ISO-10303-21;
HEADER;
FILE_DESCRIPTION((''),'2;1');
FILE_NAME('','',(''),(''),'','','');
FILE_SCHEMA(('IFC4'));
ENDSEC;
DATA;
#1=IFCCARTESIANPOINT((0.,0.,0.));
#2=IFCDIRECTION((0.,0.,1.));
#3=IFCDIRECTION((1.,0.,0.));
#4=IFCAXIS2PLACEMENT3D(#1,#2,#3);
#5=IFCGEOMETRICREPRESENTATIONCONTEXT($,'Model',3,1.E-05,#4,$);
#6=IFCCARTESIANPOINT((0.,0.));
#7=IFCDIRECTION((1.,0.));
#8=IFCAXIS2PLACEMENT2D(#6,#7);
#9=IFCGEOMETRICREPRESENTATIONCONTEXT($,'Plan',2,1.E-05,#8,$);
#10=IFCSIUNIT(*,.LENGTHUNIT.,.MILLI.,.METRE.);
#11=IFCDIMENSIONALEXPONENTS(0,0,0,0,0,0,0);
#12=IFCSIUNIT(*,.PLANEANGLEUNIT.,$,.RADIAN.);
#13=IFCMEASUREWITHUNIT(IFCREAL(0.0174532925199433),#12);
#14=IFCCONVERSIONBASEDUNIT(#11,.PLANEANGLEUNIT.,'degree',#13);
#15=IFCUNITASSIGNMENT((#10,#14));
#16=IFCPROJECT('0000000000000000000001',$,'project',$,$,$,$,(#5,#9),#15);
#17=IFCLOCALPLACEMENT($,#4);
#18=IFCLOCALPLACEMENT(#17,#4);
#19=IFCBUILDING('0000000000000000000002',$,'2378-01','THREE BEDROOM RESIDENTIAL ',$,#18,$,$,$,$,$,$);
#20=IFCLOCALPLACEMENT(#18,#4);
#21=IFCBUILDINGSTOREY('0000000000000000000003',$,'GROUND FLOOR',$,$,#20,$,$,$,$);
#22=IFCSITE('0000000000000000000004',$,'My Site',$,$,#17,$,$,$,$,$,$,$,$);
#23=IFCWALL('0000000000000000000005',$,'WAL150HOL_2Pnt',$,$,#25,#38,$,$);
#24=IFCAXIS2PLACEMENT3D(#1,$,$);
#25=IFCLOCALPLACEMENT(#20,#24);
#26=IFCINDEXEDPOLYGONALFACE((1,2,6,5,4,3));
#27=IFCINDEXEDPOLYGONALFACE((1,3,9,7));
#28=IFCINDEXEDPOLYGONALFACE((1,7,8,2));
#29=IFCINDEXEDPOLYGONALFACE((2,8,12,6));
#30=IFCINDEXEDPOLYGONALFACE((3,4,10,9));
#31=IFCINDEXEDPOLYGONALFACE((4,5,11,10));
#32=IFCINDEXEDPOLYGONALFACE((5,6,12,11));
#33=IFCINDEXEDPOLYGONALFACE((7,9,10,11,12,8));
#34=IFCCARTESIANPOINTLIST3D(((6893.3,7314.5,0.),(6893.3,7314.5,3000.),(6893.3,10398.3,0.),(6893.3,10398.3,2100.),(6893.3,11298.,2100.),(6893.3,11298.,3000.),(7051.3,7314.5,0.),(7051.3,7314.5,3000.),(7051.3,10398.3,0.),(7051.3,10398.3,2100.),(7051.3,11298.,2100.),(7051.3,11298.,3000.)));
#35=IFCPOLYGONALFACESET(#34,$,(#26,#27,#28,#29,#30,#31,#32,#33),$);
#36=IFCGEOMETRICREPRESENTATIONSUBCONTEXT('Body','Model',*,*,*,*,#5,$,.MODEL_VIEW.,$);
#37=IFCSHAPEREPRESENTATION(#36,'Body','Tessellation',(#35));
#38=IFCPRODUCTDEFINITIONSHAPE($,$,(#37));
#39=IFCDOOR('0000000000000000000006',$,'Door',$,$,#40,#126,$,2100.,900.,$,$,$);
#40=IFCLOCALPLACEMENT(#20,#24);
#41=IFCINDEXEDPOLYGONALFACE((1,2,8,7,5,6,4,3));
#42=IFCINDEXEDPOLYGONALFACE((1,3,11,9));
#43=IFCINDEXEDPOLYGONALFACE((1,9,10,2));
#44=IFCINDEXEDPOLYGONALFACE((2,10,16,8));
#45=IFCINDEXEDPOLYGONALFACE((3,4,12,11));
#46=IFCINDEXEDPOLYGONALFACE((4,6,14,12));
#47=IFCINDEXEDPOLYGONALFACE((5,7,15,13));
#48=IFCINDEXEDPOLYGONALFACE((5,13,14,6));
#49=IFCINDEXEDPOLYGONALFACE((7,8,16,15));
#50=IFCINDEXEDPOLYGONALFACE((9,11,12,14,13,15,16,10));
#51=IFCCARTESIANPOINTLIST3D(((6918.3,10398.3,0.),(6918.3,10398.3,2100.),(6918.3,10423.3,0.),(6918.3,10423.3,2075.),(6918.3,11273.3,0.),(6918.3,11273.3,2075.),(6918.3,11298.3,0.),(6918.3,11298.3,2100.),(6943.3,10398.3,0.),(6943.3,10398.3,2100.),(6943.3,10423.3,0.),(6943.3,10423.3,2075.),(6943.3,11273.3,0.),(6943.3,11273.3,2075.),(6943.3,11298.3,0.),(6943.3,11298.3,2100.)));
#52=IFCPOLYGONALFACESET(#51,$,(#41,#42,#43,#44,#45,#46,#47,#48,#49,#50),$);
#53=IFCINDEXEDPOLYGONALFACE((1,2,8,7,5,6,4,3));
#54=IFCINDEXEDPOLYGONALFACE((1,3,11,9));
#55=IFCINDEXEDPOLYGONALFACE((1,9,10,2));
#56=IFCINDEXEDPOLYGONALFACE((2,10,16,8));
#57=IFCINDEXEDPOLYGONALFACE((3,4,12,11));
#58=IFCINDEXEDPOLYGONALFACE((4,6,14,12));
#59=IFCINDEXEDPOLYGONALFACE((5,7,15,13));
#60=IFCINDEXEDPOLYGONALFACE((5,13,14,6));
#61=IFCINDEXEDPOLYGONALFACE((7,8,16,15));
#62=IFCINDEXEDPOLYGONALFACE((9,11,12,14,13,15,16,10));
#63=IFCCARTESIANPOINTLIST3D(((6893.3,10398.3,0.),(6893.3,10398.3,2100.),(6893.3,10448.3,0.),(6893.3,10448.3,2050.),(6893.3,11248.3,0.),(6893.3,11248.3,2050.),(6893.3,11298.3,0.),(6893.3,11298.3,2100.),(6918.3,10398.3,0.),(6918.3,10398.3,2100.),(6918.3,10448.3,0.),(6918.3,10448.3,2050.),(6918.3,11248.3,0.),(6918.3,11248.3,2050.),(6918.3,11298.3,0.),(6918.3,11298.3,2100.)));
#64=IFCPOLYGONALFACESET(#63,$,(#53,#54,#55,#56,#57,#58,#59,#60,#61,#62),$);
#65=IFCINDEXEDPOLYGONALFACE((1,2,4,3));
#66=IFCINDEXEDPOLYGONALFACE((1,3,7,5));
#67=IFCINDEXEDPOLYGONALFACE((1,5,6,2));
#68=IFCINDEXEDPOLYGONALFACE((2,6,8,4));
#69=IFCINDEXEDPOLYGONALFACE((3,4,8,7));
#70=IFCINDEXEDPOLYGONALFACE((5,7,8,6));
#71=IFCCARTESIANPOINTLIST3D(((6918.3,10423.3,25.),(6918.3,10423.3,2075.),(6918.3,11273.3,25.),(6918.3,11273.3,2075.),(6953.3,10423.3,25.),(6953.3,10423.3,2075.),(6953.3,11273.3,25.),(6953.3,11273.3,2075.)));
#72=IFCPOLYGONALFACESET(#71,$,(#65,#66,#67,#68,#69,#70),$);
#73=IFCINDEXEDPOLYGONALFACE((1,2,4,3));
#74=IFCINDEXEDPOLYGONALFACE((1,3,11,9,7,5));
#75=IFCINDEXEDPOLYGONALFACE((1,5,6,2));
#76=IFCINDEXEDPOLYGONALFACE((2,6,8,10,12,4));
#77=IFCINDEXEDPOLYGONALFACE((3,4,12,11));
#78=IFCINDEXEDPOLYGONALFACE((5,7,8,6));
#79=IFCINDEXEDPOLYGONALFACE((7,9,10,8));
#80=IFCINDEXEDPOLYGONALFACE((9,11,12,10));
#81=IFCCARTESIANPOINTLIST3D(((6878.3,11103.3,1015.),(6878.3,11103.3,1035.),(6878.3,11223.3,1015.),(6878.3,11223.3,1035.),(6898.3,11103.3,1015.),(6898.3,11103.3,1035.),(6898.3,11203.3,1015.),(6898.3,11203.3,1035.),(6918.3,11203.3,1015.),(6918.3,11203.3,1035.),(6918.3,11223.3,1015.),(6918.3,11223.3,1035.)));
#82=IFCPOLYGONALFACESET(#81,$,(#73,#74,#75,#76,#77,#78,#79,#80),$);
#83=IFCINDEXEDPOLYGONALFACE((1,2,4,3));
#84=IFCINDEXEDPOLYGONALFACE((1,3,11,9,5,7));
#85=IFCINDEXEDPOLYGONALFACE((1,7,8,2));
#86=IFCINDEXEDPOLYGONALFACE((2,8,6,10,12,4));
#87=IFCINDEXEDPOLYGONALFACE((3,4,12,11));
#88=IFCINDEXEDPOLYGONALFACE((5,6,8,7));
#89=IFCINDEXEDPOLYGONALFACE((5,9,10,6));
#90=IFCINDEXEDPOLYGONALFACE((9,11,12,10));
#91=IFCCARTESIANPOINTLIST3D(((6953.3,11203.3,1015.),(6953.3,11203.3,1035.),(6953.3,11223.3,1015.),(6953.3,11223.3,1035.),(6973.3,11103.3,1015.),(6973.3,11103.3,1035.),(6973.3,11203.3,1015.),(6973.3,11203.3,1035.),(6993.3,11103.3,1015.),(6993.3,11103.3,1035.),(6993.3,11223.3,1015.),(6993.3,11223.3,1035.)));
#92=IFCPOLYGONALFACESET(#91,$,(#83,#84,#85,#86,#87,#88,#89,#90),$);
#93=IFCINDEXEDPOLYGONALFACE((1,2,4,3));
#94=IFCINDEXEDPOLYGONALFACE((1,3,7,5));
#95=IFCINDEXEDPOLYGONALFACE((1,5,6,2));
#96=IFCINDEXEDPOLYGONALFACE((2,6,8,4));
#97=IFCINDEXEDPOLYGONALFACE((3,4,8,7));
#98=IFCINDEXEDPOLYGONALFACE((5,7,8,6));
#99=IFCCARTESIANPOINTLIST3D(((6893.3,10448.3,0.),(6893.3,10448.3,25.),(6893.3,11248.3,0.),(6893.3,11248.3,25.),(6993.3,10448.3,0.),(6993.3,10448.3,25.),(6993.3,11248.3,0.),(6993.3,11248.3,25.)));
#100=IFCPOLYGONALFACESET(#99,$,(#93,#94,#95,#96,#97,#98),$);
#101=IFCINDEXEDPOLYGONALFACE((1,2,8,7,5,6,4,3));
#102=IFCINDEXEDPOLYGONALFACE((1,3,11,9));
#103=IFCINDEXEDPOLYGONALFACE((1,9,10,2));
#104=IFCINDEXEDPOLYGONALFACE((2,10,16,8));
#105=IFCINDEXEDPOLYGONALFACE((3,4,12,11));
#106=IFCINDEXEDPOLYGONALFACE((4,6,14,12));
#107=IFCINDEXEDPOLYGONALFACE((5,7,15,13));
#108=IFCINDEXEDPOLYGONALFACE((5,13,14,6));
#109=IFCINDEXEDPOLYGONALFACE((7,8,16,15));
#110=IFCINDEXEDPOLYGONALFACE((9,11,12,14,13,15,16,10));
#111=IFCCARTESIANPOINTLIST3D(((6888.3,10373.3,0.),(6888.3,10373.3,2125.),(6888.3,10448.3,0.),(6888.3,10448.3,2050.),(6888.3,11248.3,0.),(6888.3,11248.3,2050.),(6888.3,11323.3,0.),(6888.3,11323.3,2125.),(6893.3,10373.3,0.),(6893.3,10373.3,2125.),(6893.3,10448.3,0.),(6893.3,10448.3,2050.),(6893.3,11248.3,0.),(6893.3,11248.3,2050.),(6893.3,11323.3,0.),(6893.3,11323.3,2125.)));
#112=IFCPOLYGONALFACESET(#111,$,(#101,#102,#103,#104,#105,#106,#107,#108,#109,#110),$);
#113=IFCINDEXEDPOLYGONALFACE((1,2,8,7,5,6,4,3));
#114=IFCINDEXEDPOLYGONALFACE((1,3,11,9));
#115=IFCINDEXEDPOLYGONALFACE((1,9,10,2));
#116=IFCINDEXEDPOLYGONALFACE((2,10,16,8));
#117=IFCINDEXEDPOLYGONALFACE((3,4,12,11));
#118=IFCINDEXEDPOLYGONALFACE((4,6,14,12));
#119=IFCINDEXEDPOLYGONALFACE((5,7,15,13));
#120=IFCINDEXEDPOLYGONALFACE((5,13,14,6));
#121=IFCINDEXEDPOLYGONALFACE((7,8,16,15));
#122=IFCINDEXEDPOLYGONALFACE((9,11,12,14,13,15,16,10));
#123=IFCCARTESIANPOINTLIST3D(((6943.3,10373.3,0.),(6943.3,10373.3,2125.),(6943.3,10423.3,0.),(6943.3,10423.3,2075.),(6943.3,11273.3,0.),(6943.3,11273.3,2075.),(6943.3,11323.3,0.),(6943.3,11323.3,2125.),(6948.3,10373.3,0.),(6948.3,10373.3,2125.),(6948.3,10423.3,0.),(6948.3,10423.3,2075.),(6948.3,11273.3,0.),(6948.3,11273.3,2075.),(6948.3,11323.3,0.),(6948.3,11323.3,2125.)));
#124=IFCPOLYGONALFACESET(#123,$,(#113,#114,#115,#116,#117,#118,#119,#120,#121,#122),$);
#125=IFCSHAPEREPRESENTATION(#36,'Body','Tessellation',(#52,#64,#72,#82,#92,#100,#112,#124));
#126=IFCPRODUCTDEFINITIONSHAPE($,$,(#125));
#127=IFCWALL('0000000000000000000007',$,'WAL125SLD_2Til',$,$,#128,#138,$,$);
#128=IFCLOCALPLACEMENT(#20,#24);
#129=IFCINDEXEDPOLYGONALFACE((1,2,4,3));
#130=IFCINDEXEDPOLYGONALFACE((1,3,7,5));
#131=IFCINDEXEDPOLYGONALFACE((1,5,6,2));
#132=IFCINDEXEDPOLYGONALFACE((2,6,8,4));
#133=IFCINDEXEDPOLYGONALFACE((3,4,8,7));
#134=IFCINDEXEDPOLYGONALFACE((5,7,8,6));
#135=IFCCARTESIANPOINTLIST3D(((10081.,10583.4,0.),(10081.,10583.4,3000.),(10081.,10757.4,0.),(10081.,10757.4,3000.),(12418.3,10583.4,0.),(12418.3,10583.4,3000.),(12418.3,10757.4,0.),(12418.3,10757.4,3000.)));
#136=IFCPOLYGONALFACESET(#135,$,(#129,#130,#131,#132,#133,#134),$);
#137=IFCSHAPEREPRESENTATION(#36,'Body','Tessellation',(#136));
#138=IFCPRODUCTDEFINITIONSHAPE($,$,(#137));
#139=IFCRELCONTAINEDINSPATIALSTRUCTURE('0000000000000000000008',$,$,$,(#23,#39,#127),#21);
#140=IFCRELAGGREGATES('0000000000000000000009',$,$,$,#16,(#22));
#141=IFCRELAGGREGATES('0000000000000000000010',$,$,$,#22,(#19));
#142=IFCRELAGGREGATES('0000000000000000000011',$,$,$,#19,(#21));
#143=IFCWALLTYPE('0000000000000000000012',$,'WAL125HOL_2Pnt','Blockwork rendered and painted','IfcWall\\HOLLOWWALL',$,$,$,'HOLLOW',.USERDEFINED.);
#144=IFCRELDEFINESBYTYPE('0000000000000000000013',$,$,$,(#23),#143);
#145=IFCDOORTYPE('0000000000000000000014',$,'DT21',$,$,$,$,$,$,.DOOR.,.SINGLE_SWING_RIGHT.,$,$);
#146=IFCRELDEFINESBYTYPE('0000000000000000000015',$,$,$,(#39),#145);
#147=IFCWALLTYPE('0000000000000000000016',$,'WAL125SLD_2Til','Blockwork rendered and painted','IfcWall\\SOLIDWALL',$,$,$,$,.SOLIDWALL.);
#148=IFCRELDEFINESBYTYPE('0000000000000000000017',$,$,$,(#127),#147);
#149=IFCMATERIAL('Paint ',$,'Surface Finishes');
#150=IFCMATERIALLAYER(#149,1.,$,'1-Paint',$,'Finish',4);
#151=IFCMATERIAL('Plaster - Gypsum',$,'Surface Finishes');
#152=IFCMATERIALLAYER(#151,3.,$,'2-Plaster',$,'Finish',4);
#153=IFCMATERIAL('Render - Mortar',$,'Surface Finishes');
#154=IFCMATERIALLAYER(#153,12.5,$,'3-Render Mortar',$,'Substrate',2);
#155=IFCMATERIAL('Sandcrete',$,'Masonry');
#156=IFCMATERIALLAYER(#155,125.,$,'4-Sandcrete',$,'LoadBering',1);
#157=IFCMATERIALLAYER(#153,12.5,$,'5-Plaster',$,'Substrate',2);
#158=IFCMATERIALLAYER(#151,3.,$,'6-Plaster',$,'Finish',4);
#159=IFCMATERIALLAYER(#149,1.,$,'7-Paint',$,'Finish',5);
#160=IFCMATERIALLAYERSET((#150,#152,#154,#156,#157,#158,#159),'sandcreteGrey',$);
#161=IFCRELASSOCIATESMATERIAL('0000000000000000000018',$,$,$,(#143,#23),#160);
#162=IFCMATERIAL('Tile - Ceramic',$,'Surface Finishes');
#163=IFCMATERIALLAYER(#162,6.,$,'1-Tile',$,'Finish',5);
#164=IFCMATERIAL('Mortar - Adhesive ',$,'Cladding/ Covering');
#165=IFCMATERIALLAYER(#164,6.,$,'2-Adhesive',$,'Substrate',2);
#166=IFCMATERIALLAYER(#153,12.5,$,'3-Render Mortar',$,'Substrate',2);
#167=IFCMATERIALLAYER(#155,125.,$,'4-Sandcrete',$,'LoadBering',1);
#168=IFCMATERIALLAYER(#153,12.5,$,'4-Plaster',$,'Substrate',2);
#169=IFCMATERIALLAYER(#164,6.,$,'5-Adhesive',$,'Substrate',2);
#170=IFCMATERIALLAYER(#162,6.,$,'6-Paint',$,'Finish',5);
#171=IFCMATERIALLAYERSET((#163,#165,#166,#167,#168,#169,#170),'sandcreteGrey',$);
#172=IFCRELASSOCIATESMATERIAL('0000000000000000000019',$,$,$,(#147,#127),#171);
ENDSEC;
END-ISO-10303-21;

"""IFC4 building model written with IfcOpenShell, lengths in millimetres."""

from ifc_helpers import new_model, entity, si_unit, converted_unit, frame, origin_with_axes, origin_2d_with_axis, place, context, subcontext, project, spatial, line, indexed_curve, outline, extrude, shape, source, transform, mapped, material, layer, layer_set, layer_usage, type_object, type_shapes, element, fill, save


model = new_model("IFC4")

# Units and contexts
model_context = context("Model", 3, precision=1e-05, world=origin_with_axes())
plan_context = context("Plan", 2, precision=1e-05, world=origin_2d_with_axis())
body_context_1 = subcontext(model_context, "Body", "Model", "MODEL_VIEW")
body_context_2 = subcontext(plan_context, "Body", "Plan", "PLAN_VIEW")
ifc_project = project(units=[si_unit("LENGTHUNIT", "METRE", prefix="MILLI"), converted_unit("PLANEANGLEUNIT", "degree", entity("IfcReal", 0.0174532925199433), si_unit("PLANEANGLEUNIT", "RADIAN"), dimensions=[0, 0, 0, 0, 0, 0, 0])], contexts=[model_context, plan_context])

# Site, building, storey
site_placement = place(None, origin_with_axes())
site = spatial("IfcSite", under=ifc_project, at=site_placement, Name="My Site")
building_placement = place(site_placement, origin_with_axes())
building = spatial("IfcBuilding", under=site, at=building_placement, Name="2378-01", Description="THREE BEDROOM RESIDENTIAL ")
storey_placement = place(building_placement, origin_with_axes())
storey = spatial("IfcBuildingStorey", under=building, at=storey_placement, Name="GROUND FLOOR")

# Shared definitions
shared_shape_1 = source(origin_with_axes(), body_context_1, "Body", "SweptSolid", [
    extrude(outline(indexed_curve([(0.0, 0.0), (900.0, 0.0), (900.0, 2100.0), (0.0, 2100.0)], segments=[line(1, 2, 3, 4, 1)])), frame((0.0, -600.0, 0.0), z_axis=(0.0, -1.0, 0.0), x_axis=(1.0, 0.0, 0.0)), (0.0, 0.0, -1.0), 1200.0),
])
door_type_1 = type_object("IfcDoorType", Name="DT21", OperationType="SINGLE_SWING_RIGHT", PredefinedType="DOOR")
shared_shape_2 = source(origin_with_axes(), body_context_1, "Body", "SweptSolid", [
    extrude(outline(indexed_curve([(0.0, 0.0), (0.0, 2100.0), (900.0, 2100.0), (900.0, 0.0), (875.0, 0.0), (875.0, 2075.0), (25.0, 2075.0), (25.0, 0.0)], segments=[line(1, 2, 3, 4, 5, 6, 7, 8, 1)])), frame((0.0, 25.0, 0.0), z_axis=(0.0, -1.0, 0.0), x_axis=(1.0, 0.0, 0.0)), (0.0, 0.0, -1.0), 25.0),
    extrude(outline(indexed_curve([(0.0, 0.0), (0.0, 2100.0), (900.0, 2100.0), (900.0, 0.0), (850.0, 0.0), (850.0, 2050.0), (50.0, 2050.0), (50.0, 0.0)], segments=[line(1, 2, 3, 4, 5, 6, 7, 8, 1)])), frame((0.0, 0.0, 0.0), z_axis=(0.0, -1.0, 0.0), x_axis=(1.0, 0.0, 0.0)), (0.0, 0.0, -1.0), 25.0),
    extrude(outline(indexed_curve([(0.0, 0.0), (850.0, 0.0), (850.0, 35.0), (0.0, 35.0)], segments=[line(1, 2, 3, 4, 1)])), frame((25.0, 25.0, 25.0), z_axis=(0.0, 0.0, 1.0), x_axis=(1.0, 0.0, 0.0)), (0.0, 0.0, 1.0), 2050.0),
    extrude(outline(indexed_curve([(0.0, 0.0), (0.0, -40.0), (120.0, -40.0), (120.0, -20.0), (20.0, -20.0), (20.0, 0.0)], segments=[line(1, 2, 3, 4, 5, 6, 1)])), frame((75.0, 25.0, 1015.0), z_axis=(0.0, 0.0, 1.0), x_axis=(1.0, 0.0, 0.0)), (0.0, 0.0, 1.0), 20.0),
    extrude(outline(indexed_curve([(0.0, 0.0), (0.0, 40.0), (120.0, 40.0), (120.0, 20.0), (20.0, 20.0), (20.0, 0.0)], segments=[line(1, 2, 3, 4, 5, 6, 1)])), frame((75.0, 60.0, 1015.0), z_axis=(0.0, 0.0, 1.0), x_axis=(1.0, 0.0, 0.0)), (0.0, 0.0, 1.0), 20.0),
    extrude(outline(indexed_curve([(0.0, 0.0), (800.0, 0.0), (800.0, 100.0), (0.0, 100.0)], segments=[line(1, 2, 3, 4, 1)])), frame((50.0, 0.0, 0.0), z_axis=(0.0, 0.0, 1.0), x_axis=(1.0, 0.0, 0.0)), (0.0, 0.0, 1.0), 25.0),
    extrude(outline(indexed_curve([(0.0, 0.0), (0.0, 2125.0), (950.0, 2125.0), (950.0, 0.0), (875.0, 0.0), (875.0, 2050.0), (75.0, 2050.0), (75.0, 0.0)], segments=[line(1, 2, 3, 4, 5, 6, 7, 8, 1)])), frame((-25.0, -5.0, 0.0), z_axis=(0.0, -1.0, 0.0), x_axis=(1.0, 0.0, 0.0)), (0.0, 0.0, -1.0), 5.0),
    extrude(outline(indexed_curve([(0.0, 0.0), (0.0, 2125.0), (950.0, 2125.0), (950.0, 0.0), (900.0, 0.0), (900.0, 2075.0), (50.0, 2075.0), (50.0, 0.0)], segments=[line(1, 2, 3, 4, 5, 6, 7, 8, 1)])), frame((-25.0, 50.0, 0.0), z_axis=(0.0, -1.0, 0.0), x_axis=(1.0, 0.0, 0.0)), (0.0, 0.0, -1.0), 5.0),
])
shared_shape_3 = source(origin_with_axes(), body_context_2, "Body", "Curve2D", [
    entity("IfcIndexedPolyCurve", entity("IfcCartesianPointList2D", [[0.0, 0.0], [0.0, 50.0], [25.0, 50.0], [25.0, 25.0], [50.0, 25.0], [50.0, 0.0]]), [entity("IfcLineIndex", [1, 2, 3, 4, 5, 6, 1])]),
    entity("IfcIndexedPolyCurve", entity("IfcCartesianPointList2D", [[900.0, 0.0], [900.0, 50.0], [875.0, 50.0], [875.0, 25.0], [850.0, 25.0], [850.0, 0.0]]), [entity("IfcLineIndex", [1, 2, 3, 4, 5, 6, 1])]),
    entity("IfcTrimmedCurve", entity("IfcEllipse", entity("IfcAxis2Placement2D", entity("IfcCartesianPoint", [840.0, 50.0]), entity("IfcDirection", [1.0, 0.0])), 815.0, 850.0), [entity("IfcCartesianPoint", [840.0, 900.0])], [entity("IfcCartesianPoint", [25.0, 50.0])], True, "CARTESIAN"),
    entity("IfcIndexedPolyCurve", entity("IfcCartesianPointList2D", [[875.0, 50.0], [840.0, 50.0], [840.0, 900.0], [875.0, 900.0]]), [entity("IfcLineIndex", [1, 2, 3, 4, 1])]),
])
type_shapes(door_type_1, [shared_shape_2, shared_shape_3])

# Wall, opening, door
ifc_material_1 = material(Name="Paint ", Category="Surface Finishes")
ifc_layer_1 = layer(ifc_material_1, 1.0, Name="1-Paint", Category="Finish", Priority=4)
ifc_material_2 = material(Name="Plaster - Gypsum", Category="Surface Finishes")
ifc_layer_2 = layer(ifc_material_2, 3.0, Name="2-Plaster", Category="Finish", Priority=4)
ifc_material_3 = material(Name="Render - Mortar", Category="Surface Finishes")
ifc_layer_3 = layer(ifc_material_3, 12.5, Name="3-Render Mortar", Category="Substrate", Priority=2)
ifc_material_4 = material(Name="Sandcrete", Category="Masonry")
ifc_layer_4 = layer(ifc_material_4, 125.0, Name="4-Sandcrete", Category="LoadBering", Priority=1)
ifc_layer_5 = layer(ifc_material_3, 12.5, Name="5-Plaster", Category="Substrate", Priority=2)
ifc_layer_6 = layer(ifc_material_2, 3.0, Name="6-Plaster", Category="Finish", Priority=4)
ifc_layer_7 = layer(ifc_material_1, 1.0, Name="7-Paint", Category="Finish", Priority=5)
ifc_layer_set_1 = layer_set([ifc_layer_1, ifc_layer_2, ifc_layer_3, ifc_layer_4, ifc_layer_5, ifc_layer_6, ifc_layer_7], Name="sandcreteGrey")
ifc_layer_usage_1 = layer_usage(ifc_layer_set_1, "AXIS2", "POSITIVE", 0.0)
wall_type_1 = type_object("IfcWallType", Name="WAL125HOL_2Pnt", Description="Blockwork rendered and painted", ApplicableOccurrence="IfcWall\\HOLLOWWALL", ElementType="HOLLOW", PredefinedType="USERDEFINED", material=ifc_layer_set_1)
wall_1_placement = place(storey_placement, frame((6893.3, 11298.0, 0.0), z_axis=(0.0, 0.0, 1.0), x_axis=(-0.000001, -1.0, 0.0)))
wall_1 = element("IfcWall", 1, at=wall_1_placement, inside=storey, type_object=wall_type_1, material=ifc_layer_usage_1, Name="WAL150HOL_2Pnt", context=body_context_1, shape_type="SweptSolid", body=[
    extrude(outline(indexed_curve([(0.0, 0.0), (0.0, 158.0), (3983.5, 158.0), (3983.5, 0.0), (0.0, 0.0)], self_intersect=False)), origin_with_axes(), (0.0, 0.0, 1.0), 3000.0),
])
opening_1_placement = place(wall_1_placement, frame((-0.3, 0.0, 0.0), z_axis=(0.0, 0.0, 1.0), x_axis=(1.0, 0.0, 0.0)))
opening_1 = element("IfcOpeningElement", 2, at=opening_1_placement, cuts=wall_1, PredefinedType="OPENING", context=body_context_1, shape_type="MappedRepresentation", body=[
    mapped(shared_shape_1, transform((0.0, 0.0, 0.0), x_axis=(1.0, 0.0, 0.0), y_axis=(0.0, 1.0, 0.0), z_axis=(0.0, 0.0, 1.0), scale=1.0)),
])
door_1_placement = place(opening_1_placement, origin_with_axes())
door_1 = element("IfcDoor", 3, at=door_1_placement, inside=storey, type_object=door_type_1, Name="Door", OverallHeight=2100.0, OverallWidth=900.0, shapes=[
    shape(body_context_1, "Body", "MappedRepresentation", [mapped(shared_shape_2, transform((0.0, 0.0, 0.0), x_axis=(1.0, 0.0, 0.0), y_axis=(0.0, 1.0, 0.0), z_axis=(0.0, 0.0, 1.0), scale=1.0))]),
    shape(body_context_2, "Body", "MappedRepresentation", [mapped(shared_shape_3, transform((0.0, 0.0, 0.0), x_axis=(1.0, 0.0, 0.0), y_axis=(0.0, 1.0, 0.0), z_axis=(0.0, 0.0, 1.0), scale=1.0))]),
])
fill(opening_1, door_1)

# Wall
ifc_material_5 = material(Name="Tile - Ceramic", Category="Surface Finishes")
ifc_layer_8 = layer(ifc_material_5, 6.0, Name="1-Tile", Category="Finish", Priority=5)
ifc_material_6 = material(Name="Mortar - Adhesive ", Category="Cladding/ Covering")
ifc_layer_9 = layer(ifc_material_6, 6.0, Name="2-Adhesive", Category="Substrate", Priority=2)
ifc_layer_10 = layer(ifc_material_3, 12.5, Name="3-Render Mortar", Category="Substrate", Priority=2)
ifc_layer_11 = layer(ifc_material_4, 125.0, Name="4-Sandcrete", Category="LoadBering", Priority=1)
ifc_layer_12 = layer(ifc_material_3, 12.5, Name="4-Plaster", Category="Substrate", Priority=2)
ifc_layer_13 = layer(ifc_material_6, 6.0, Name="5-Adhesive", Category="Substrate", Priority=2)
ifc_layer_14 = layer(ifc_material_5, 6.0, Name="6-Paint", Category="Finish", Priority=5)
ifc_layer_set_2 = layer_set([ifc_layer_8, ifc_layer_9, ifc_layer_10, ifc_layer_11, ifc_layer_12, ifc_layer_13, ifc_layer_14], Name="sandcreteGrey")
ifc_layer_usage_2 = layer_usage(ifc_layer_set_2, "AXIS2", "POSITIVE", 0.0)
wall_type_2 = type_object("IfcWallType", Name="WAL125SLD_2Til", Description="Blockwork rendered and painted", ApplicableOccurrence="IfcWall\\SOLIDWALL", PredefinedType="SOLIDWALL", material=ifc_layer_set_2)
wall_2_placement = place(storey_placement, frame((10081.0, 10583.4, 0.0), z_axis=(0.0, 0.0, 1.0), x_axis=(1.0, -0.000001, 0.0)))
element("IfcWall", 4, at=wall_2_placement, inside=storey, type_object=wall_type_2, material=ifc_layer_usage_2, Name="WAL125SLD_2Til", context=body_context_1, shape_type="SweptSolid", body=[
    extrude(outline(indexed_curve([(0.0, 0.0), (0.0, 174.0), (2337.3, 174.0), (2337.3, 0.0), (0.0, 0.0)], self_intersect=False)), origin_with_axes(), (0.0, 0.0, 1.0), 3000.0),
])

save(model, "model.ifc")
